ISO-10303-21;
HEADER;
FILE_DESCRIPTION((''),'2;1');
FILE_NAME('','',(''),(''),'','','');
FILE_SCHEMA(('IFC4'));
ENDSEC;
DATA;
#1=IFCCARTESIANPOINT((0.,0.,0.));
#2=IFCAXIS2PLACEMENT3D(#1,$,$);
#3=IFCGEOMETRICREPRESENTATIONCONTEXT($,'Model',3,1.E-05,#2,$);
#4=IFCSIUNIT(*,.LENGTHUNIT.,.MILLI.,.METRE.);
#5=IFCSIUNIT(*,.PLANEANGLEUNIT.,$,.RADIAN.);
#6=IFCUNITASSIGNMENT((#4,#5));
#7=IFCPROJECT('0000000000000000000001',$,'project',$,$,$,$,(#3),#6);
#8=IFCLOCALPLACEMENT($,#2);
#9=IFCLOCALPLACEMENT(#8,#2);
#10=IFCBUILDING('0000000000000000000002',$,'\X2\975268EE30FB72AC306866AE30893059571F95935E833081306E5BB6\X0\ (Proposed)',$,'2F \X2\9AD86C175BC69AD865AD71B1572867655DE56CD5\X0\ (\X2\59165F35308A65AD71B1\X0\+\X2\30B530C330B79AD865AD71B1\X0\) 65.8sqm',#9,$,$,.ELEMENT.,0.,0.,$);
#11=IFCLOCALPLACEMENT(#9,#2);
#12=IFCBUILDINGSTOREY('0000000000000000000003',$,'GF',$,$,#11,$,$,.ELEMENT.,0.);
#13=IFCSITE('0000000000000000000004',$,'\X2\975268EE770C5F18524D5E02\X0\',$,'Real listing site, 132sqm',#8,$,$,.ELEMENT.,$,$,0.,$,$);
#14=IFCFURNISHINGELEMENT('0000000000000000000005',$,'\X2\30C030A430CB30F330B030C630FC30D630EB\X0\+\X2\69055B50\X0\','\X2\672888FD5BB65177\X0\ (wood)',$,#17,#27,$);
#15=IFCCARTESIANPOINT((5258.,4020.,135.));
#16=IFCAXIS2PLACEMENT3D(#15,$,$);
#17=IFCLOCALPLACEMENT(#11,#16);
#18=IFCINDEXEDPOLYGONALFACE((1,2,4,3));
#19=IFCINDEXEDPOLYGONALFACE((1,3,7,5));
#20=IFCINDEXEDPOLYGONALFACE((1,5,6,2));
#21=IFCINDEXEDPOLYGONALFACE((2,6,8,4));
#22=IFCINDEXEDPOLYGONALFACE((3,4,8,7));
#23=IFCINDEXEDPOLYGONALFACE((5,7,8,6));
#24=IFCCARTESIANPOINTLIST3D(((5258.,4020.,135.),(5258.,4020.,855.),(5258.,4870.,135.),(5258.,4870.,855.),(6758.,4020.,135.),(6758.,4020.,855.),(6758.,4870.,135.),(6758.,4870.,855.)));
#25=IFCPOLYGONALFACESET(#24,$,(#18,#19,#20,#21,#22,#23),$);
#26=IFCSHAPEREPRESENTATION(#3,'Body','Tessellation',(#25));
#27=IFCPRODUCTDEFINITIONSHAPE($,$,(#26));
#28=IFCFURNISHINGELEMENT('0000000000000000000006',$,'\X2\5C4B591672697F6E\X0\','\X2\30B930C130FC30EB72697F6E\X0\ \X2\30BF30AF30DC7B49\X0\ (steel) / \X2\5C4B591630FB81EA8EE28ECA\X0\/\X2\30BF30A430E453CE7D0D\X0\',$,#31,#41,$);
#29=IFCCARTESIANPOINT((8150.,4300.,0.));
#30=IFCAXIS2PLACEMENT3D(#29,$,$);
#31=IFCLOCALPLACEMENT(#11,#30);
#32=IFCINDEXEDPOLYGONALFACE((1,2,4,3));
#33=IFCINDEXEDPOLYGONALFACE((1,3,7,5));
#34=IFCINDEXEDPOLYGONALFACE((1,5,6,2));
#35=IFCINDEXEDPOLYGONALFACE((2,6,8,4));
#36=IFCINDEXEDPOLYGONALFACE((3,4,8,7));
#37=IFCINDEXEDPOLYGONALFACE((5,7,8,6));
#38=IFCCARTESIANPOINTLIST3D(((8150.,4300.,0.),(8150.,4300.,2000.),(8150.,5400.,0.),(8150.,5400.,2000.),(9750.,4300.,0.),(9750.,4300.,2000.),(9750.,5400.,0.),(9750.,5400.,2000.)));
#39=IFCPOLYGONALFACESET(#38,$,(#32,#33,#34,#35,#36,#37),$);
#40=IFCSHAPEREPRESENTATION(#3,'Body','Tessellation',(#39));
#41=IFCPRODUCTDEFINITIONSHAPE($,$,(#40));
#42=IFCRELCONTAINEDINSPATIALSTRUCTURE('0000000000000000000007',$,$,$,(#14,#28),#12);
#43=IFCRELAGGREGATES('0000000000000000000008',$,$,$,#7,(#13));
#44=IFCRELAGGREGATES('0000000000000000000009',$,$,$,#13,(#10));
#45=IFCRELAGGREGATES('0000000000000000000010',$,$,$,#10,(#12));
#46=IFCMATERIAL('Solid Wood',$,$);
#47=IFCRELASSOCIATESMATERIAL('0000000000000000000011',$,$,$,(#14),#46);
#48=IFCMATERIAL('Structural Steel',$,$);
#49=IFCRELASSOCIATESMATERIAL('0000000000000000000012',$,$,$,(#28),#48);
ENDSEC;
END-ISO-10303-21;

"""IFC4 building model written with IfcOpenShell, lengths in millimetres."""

from ifc_helpers import new_model, si_unit, frame, frame_2d, origin, place, context, project, spatial, rectangle, extrude, material, element, save


model = new_model("IFC4")

# Units and contexts
model_context = context("Model", 3, precision=1e-05, world=origin())
ifc_project = project(units=[si_unit("LENGTHUNIT", "METRE", prefix="MILLI"), si_unit("PLANEANGLEUNIT", "RADIAN")], contexts=[model_context])

# Site, building, storey
site_placement = place(None, origin())
site = spatial("IfcSite", under=ifc_project, at=site_placement, Name="青森県弘前市", ObjectType="Real listing site, 132sqm", CompositionType="ELEMENT", RefElevation=0.0)
building_placement = place(site_placement, origin())
building = spatial("IfcBuilding", under=site, at=building_placement, Name="青森・犬と暮らす土間広めの家 (Proposed)", ObjectType="2F 高気密高断熱在来工法 (外張り断熱+サッシ高断熱) 65.8sqm", CompositionType="ELEMENT", ElevationOfRefHeight=0.0, ElevationOfTerrain=0.0)
storey_placement = place(building_placement, origin())
storey = spatial("IfcBuildingStorey", under=building, at=storey_placement, Name="GF", CompositionType="ELEMENT", Elevation=0.0)

# Shared definitions
ifc_material_1 = material(Name="Solid Wood")

# Shared definitions
ifc_material_2 = material(Name="Structural Steel")

# Furnishing elements
furnishing_1_placement = place(storey_placement, frame((5258.0, 4020.0, 135.0)))
element("IfcFurnishingElement", 1, at=furnishing_1_placement, inside=storey, material=ifc_material_1, Name="ダイニングテーブル+椅子", Description="木製家具 (wood)", context=model_context, shape_type="SweptSolid", body=[
    extrude(rectangle(XDim=1500.0, YDim=850.0, at=frame_2d((750.0, 425.0))), frame((5258.0, 4020.0, 135.0)), (0.0, 0.0, 1.0), 720.0),
])
furnishing_2_placement = place(storey_placement, frame((8150.0, 4300.0, 0.0)))
element("IfcFurnishingElement", 2, at=furnishing_2_placement, inside=storey, material=ifc_material_2, Name="屋外物置", Description="スチール物置 タクボ等 (steel) / 屋外・自転車/タイヤ収納", context=model_context, shape_type="SweptSolid", body=[
    extrude(rectangle(XDim=1600.0, YDim=1100.0, at=frame_2d((800.0, 550.0))), frame((8150.0, 4300.0, 0.0)), (0.0, 0.0, 1.0), 2000.0),
])

save(model, "model.ifc")
